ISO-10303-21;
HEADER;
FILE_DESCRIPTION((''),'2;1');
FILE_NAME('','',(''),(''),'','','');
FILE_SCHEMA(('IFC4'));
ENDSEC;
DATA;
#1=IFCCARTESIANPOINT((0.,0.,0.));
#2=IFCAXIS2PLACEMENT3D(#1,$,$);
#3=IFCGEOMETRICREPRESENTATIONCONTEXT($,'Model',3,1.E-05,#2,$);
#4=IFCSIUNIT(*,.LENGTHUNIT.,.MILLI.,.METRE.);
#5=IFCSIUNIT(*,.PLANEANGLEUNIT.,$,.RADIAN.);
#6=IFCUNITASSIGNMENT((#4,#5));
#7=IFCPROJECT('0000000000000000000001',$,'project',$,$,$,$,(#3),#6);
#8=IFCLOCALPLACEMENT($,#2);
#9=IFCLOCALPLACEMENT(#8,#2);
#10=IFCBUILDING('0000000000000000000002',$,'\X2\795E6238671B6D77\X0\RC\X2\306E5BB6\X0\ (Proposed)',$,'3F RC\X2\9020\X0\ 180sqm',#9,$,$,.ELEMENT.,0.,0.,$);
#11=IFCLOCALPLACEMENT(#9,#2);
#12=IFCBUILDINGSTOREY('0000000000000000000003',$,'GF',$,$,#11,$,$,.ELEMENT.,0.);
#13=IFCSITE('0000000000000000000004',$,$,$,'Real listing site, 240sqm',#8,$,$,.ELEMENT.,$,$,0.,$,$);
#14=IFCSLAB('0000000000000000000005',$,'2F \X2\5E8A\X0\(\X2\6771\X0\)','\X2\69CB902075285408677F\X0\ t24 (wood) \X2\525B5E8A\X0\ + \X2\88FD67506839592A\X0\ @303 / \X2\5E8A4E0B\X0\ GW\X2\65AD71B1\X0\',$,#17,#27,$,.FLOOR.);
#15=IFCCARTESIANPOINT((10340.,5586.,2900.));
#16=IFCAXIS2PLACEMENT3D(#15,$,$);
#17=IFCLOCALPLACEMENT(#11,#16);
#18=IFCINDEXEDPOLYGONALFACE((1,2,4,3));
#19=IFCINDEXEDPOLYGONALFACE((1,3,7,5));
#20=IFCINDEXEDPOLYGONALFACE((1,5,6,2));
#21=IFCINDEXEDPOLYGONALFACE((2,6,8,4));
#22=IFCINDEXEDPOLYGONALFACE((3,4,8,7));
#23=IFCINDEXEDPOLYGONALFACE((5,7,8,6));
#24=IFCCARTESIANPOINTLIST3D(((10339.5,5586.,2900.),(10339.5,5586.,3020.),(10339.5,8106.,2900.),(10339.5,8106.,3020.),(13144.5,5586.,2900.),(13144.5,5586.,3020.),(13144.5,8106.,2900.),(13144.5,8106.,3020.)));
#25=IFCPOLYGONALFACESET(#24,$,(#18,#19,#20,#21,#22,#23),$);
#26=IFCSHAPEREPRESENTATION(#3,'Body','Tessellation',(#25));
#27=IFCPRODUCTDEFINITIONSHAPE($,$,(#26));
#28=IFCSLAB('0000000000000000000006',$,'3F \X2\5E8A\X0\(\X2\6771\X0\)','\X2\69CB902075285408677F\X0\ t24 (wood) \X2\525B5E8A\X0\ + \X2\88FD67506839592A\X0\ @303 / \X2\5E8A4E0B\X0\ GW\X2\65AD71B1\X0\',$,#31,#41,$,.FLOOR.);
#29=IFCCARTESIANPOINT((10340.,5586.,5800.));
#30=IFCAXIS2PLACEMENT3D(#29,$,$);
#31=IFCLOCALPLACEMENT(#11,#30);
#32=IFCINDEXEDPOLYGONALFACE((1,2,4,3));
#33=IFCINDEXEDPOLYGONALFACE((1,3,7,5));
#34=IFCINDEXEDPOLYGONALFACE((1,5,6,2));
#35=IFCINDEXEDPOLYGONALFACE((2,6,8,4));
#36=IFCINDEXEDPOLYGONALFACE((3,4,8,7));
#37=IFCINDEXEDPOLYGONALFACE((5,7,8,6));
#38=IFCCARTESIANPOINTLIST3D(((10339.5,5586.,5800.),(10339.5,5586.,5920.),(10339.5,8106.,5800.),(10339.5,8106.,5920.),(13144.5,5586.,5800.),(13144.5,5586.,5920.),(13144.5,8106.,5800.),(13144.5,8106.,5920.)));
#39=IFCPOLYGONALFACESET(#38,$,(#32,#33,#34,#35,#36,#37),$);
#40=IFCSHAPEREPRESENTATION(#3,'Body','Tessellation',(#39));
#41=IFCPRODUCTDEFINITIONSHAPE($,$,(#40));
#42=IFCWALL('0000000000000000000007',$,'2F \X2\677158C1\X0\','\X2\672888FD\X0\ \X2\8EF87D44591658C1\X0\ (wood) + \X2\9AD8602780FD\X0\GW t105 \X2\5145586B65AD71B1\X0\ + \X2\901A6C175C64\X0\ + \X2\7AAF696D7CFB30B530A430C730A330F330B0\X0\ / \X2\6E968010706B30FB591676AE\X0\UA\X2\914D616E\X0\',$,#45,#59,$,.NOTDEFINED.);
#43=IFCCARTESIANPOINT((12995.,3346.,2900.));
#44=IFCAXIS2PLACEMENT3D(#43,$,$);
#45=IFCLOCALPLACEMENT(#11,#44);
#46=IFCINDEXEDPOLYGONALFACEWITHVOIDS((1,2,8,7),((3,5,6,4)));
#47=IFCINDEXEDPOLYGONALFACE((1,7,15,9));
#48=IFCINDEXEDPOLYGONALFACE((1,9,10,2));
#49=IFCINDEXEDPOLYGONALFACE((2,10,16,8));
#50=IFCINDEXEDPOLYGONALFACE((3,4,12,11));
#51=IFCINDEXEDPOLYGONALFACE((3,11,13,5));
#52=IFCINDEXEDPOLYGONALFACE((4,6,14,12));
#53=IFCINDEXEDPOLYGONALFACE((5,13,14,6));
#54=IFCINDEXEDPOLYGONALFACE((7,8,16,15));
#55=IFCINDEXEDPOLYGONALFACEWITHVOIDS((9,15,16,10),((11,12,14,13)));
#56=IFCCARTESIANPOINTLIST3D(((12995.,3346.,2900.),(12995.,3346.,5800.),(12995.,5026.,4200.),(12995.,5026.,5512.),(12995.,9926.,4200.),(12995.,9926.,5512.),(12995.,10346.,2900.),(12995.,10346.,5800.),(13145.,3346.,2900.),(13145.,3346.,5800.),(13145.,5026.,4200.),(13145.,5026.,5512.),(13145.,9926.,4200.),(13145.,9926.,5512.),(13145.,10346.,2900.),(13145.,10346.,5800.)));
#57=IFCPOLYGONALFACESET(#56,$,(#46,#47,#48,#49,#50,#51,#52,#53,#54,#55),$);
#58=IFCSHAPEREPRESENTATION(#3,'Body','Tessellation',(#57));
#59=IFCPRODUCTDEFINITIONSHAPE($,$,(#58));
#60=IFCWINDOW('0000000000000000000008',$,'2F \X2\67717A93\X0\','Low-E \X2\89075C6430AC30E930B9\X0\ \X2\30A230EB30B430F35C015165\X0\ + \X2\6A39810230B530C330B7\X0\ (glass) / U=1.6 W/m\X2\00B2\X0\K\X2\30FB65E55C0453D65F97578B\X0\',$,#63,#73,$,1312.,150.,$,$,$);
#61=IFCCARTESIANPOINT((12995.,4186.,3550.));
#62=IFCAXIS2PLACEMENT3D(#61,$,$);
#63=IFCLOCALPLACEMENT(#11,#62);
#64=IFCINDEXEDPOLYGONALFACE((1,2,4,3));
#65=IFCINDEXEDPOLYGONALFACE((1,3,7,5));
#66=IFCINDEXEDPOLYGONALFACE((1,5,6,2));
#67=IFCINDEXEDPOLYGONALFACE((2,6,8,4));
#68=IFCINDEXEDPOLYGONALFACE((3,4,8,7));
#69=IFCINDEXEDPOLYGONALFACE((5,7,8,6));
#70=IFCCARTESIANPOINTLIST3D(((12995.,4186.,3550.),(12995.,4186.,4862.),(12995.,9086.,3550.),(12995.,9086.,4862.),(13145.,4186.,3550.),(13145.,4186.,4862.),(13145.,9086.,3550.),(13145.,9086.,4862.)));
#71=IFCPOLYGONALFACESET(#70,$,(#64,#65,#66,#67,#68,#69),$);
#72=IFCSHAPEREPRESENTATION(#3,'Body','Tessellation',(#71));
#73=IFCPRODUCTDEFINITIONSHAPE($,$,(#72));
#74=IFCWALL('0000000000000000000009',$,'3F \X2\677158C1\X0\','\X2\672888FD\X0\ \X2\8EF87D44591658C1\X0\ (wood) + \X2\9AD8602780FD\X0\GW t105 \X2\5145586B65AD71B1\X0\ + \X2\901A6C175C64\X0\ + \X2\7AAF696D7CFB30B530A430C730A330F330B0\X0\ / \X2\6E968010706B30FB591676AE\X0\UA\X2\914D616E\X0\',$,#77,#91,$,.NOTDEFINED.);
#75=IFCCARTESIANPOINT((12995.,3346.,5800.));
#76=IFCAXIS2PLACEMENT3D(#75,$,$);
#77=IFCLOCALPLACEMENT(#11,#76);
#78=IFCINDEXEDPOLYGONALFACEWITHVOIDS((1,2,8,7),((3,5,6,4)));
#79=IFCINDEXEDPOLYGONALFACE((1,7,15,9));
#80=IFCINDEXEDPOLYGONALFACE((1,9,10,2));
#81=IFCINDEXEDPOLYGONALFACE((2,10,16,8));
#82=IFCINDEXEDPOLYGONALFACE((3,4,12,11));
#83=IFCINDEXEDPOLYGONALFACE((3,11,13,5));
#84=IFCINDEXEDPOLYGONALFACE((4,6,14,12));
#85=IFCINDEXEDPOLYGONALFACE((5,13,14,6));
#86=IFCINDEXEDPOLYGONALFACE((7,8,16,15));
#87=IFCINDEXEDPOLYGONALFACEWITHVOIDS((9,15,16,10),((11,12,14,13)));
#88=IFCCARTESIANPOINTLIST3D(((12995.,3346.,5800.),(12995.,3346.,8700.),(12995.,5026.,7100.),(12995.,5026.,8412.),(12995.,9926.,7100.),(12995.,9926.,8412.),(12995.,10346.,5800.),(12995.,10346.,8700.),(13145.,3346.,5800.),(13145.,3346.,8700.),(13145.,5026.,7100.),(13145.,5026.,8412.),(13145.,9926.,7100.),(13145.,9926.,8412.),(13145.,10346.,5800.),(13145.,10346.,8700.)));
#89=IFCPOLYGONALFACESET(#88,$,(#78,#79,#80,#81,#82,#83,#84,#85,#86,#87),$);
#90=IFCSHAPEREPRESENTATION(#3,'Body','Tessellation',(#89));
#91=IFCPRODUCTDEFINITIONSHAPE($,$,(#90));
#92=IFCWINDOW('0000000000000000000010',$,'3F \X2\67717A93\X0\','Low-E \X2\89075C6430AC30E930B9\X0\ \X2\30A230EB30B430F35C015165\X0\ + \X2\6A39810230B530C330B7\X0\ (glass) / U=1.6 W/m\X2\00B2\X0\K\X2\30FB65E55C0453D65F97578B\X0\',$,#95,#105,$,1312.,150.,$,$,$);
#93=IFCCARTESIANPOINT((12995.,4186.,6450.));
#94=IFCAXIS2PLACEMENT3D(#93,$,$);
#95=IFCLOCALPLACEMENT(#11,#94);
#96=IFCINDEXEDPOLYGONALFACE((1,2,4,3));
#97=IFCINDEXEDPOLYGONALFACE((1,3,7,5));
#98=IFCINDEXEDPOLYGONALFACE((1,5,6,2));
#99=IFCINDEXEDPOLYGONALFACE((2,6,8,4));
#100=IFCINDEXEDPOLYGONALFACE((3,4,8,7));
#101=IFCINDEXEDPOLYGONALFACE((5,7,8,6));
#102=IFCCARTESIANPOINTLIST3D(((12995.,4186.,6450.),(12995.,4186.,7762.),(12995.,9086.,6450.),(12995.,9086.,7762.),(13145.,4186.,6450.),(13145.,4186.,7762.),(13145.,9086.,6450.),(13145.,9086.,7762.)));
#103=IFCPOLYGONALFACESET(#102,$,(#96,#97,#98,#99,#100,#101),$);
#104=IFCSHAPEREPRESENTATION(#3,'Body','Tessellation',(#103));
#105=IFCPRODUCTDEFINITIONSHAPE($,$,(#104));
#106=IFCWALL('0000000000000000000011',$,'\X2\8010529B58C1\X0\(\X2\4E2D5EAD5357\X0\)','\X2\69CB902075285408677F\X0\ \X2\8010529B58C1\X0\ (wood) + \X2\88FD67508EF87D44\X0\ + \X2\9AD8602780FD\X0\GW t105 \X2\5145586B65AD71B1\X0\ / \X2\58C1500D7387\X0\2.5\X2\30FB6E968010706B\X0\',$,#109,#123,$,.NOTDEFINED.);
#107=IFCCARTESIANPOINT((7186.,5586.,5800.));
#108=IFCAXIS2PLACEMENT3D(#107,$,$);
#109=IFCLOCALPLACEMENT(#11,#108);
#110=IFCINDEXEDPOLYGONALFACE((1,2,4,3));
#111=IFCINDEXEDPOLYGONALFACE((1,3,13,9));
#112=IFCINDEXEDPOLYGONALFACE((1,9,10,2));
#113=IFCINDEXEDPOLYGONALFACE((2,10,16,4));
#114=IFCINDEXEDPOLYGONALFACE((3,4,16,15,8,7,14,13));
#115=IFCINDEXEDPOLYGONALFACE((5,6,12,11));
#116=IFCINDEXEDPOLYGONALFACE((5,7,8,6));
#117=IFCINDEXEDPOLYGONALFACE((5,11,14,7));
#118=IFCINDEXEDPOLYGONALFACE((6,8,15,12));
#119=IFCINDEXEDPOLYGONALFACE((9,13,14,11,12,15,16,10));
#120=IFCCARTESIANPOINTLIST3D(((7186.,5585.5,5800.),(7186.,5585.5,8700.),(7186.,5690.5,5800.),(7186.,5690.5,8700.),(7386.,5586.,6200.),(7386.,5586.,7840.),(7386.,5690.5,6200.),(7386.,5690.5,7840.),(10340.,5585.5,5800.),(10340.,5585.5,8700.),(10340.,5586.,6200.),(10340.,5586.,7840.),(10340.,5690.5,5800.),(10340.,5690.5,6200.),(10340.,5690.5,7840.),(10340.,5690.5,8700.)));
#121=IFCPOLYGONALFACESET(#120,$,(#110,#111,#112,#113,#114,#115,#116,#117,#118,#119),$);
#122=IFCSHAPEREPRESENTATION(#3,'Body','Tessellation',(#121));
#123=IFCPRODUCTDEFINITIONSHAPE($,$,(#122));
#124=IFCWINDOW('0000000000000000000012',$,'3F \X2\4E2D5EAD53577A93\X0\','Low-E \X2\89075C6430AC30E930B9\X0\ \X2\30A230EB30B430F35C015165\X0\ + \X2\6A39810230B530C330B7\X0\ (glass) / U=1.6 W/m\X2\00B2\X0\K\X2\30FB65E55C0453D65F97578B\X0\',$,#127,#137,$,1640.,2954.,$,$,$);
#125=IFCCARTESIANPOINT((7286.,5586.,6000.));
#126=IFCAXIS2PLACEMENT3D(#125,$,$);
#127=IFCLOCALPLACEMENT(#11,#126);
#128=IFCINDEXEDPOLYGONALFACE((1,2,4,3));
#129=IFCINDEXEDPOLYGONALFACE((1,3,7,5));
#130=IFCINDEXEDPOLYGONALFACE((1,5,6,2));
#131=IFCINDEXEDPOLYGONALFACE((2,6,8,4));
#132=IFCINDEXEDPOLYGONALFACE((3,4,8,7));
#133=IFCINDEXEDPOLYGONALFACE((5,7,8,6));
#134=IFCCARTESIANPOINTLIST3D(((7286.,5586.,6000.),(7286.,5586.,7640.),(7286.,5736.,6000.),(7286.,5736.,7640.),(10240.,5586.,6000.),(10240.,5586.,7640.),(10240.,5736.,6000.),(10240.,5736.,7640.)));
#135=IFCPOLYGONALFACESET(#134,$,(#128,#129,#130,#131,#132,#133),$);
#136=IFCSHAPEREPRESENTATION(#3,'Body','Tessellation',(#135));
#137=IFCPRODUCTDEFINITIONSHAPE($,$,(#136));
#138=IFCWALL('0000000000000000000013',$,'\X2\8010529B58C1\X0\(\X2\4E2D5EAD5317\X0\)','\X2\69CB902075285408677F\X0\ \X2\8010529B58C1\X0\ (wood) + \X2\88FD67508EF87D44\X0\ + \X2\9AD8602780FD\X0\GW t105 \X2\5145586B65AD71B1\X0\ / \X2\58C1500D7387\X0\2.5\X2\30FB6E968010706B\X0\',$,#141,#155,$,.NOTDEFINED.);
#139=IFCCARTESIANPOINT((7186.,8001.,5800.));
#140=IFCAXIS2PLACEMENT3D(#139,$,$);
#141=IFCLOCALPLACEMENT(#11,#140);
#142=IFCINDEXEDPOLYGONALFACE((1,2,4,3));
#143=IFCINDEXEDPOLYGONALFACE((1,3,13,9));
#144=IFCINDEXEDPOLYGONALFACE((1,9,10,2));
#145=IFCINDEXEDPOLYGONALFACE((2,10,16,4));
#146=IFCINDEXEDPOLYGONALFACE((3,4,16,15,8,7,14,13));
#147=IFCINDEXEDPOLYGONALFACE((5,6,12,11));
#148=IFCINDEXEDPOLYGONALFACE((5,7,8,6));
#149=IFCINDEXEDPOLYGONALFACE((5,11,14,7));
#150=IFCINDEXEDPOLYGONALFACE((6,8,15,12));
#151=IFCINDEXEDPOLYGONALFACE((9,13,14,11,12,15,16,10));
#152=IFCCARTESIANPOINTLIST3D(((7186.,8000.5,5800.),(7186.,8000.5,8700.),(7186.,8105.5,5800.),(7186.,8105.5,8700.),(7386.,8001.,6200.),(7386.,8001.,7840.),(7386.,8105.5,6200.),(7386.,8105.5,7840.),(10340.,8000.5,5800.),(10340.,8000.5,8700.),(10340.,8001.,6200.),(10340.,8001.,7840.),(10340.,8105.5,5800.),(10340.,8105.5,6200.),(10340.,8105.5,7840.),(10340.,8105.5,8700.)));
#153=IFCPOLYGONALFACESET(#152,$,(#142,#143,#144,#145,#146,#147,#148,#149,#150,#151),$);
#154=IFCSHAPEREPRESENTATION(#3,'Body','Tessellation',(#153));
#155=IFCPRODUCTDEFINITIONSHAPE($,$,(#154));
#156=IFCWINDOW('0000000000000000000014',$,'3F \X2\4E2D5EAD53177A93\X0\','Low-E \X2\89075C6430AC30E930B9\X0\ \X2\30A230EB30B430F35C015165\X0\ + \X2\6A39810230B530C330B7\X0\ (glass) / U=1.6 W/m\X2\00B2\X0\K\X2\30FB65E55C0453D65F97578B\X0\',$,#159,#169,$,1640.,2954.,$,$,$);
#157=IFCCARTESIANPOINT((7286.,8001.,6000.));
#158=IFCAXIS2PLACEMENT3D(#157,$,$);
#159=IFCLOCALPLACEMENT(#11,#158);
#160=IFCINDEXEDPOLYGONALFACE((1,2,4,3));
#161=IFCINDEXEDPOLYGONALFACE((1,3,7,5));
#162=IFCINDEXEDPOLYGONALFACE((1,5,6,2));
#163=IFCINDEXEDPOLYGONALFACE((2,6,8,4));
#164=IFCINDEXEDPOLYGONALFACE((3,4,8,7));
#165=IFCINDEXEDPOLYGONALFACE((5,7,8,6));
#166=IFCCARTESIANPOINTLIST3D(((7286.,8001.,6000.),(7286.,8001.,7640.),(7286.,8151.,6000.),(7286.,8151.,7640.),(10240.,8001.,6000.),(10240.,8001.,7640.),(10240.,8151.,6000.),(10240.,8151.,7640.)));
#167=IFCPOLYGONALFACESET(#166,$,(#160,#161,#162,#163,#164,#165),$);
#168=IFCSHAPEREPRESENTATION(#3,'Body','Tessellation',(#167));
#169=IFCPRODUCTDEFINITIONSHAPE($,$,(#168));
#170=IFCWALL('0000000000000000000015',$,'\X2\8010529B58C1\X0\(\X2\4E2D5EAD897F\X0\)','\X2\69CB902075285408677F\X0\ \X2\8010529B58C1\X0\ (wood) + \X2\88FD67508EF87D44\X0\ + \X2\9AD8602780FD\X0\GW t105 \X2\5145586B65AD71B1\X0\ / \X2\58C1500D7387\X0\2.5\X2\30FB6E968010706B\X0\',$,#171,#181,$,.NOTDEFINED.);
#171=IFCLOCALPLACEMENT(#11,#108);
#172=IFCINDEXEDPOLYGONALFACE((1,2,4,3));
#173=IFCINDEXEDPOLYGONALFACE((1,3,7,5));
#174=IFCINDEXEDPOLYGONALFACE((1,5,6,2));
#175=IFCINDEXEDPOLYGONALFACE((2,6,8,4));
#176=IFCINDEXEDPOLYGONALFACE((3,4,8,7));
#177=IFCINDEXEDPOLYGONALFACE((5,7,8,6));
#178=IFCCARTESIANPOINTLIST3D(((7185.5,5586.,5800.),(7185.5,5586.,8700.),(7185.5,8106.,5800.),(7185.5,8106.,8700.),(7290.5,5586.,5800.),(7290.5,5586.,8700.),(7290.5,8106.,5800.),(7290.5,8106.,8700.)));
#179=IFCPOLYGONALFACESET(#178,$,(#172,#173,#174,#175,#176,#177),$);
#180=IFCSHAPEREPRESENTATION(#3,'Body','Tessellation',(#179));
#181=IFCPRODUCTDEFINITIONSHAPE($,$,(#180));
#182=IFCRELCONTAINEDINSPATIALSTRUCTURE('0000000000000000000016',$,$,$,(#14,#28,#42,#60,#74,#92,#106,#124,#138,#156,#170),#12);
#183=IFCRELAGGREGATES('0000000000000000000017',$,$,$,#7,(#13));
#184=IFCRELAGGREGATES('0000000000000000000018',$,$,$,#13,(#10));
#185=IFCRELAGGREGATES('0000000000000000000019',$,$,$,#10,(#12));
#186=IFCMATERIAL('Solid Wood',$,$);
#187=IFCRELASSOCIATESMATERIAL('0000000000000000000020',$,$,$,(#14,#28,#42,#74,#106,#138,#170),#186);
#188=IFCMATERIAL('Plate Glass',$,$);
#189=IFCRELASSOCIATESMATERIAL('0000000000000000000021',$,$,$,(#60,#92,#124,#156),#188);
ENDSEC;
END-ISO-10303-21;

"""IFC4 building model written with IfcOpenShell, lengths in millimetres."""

from ifc_helpers import new_model, si_unit, frame, frame_2d, origin, place, context, project, spatial, rectangle, extrude, material, element, fill, save


model = new_model("IFC4")

# Units and contexts
model_context = context("Model", 3, precision=1e-05, world=origin())
ifc_project = project(units=[si_unit("LENGTHUNIT", "METRE", prefix="MILLI"), si_unit("PLANEANGLEUNIT", "RADIAN")], contexts=[model_context])

# Site, building, storey
site_placement = place(None, origin())
site = spatial("IfcSite", under=ifc_project, at=site_placement, ObjectType="Real listing site, 240sqm", CompositionType="ELEMENT", RefElevation=0.0)
building_placement = place(site_placement, origin())
building = spatial("IfcBuilding", under=site, at=building_placement, Name="神戸望海RCの家 (Proposed)", ObjectType="3F RC造 180sqm", CompositionType="ELEMENT", ElevationOfRefHeight=0.0, ElevationOfTerrain=0.0)
storey_placement = place(building_placement, origin())
storey = spatial("IfcBuildingStorey", under=building, at=storey_placement, Name="GF", CompositionType="ELEMENT", Elevation=0.0)

# Slabs
ifc_material_1 = material(Name="Solid Wood")
slab_1_placement = place(storey_placement, frame((10340.0, 5586.0, 2900.0)))
element("IfcSlab", 1, at=slab_1_placement, inside=storey, material=ifc_material_1, Name="2F 床(東)", Description="構造用合板 t24 (wood) 剛床 + 製材根太 @303 / 床下 GW断熱", PredefinedType="FLOOR", context=model_context, shape_type="SweptSolid", body=[
    extrude(rectangle(XDim=2805.0, YDim=2520.0, at=frame_2d((1402.0, 1260.0))), frame((10340.0, 5586.0, 2900.0)), (0.0, 0.0, 1.0), 120.0),
])
slab_2_placement = place(storey_placement, frame((10340.0, 5586.0, 5800.0)))
element("IfcSlab", 2, at=slab_2_placement, inside=storey, material=ifc_material_1, Name="3F 床(東)", Description="構造用合板 t24 (wood) 剛床 + 製材根太 @303 / 床下 GW断熱", PredefinedType="FLOOR", context=model_context, shape_type="SweptSolid", body=[
    extrude(rectangle(XDim=2805.0, YDim=2520.0, at=frame_2d((1402.0, 1260.0))), frame((10340.0, 5586.0, 5800.0)), (0.0, 0.0, 1.0), 120.0),
])

# Walls, openings, windows
wall_1_placement = place(storey_placement, frame((12995.0, 3346.0, 2900.0)))
wall_1 = element("IfcWall", 3, at=wall_1_placement, inside=storey, material=ifc_material_1, Name="2F 東壁", Description="木製 軸組外壁 (wood) + 高性能GW t105 充填断熱 + 通気層 + 窯業系サイディング / 準耐火・外皮UA配慮", PredefinedType="NOTDEFINED", context=model_context, shape_type="SweptSolid", body=[
    extrude(rectangle(XDim=150.0, YDim=7000.0, at=frame_2d((75.0, 3500.0))), frame((12995.0, 3346.0, 2900.0)), (0.0, 0.0, 1.0), 2900.0),
])
opening_1_placement = place(storey_placement, frame((12995.0, 4186.0, 3550.0)))
opening_1 = element("IfcOpeningElement", 4, at=opening_1_placement, cuts=wall_1, PredefinedType="NOTDEFINED", context=model_context, shape_type="SweptSolid", body=[
    extrude(rectangle(XDim=150.0, YDim=4900.0, at=frame_2d((75.0, 2450.0))), frame((12995.0, 4186.0, 3550.0)), (0.0, 0.0, 1.0), 1312.0),
])
ifc_material_2 = material(Name="Plate Glass")
window_1_placement = place(storey_placement, frame((12995.0, 4186.0, 3550.0)))
window_1 = element("IfcWindow", 5, at=window_1_placement, inside=storey, material=ifc_material_2, Name="2F 東窓", Description="Low-E 複層ガラス アルゴン封入 + 樹脂サッシ (glass) / U=1.6 W/m²K・日射取得型", OverallHeight=1312.0, OverallWidth=150.0, context=model_context, shape_type="SweptSolid", body=[
    extrude(rectangle(XDim=150.0, YDim=4900.0, at=frame_2d((75.0, 2450.0))), frame((12995.0, 4186.0, 3550.0)), (0.0, 0.0, 1.0), 1312.0),
])
fill(opening_1, window_1)
wall_2_placement = place(storey_placement, frame((12995.0, 3346.0, 5800.0)))
wall_2 = element("IfcWall", 6, at=wall_2_placement, inside=storey, material=ifc_material_1, Name="3F 東壁", Description="木製 軸組外壁 (wood) + 高性能GW t105 充填断熱 + 通気層 + 窯業系サイディング / 準耐火・外皮UA配慮", PredefinedType="NOTDEFINED", context=model_context, shape_type="SweptSolid", body=[
    extrude(rectangle(XDim=150.0, YDim=7000.0, at=frame_2d((75.0, 3500.0))), frame((12995.0, 3346.0, 5800.0)), (0.0, 0.0, 1.0), 2900.0),
])
opening_2_placement = place(storey_placement, frame((12995.0, 4186.0, 6450.0)))
opening_2 = element("IfcOpeningElement", 7, at=opening_2_placement, cuts=wall_2, PredefinedType="NOTDEFINED", context=model_context, shape_type="SweptSolid", body=[
    extrude(rectangle(XDim=150.0, YDim=4900.0, at=frame_2d((75.0, 2450.0))), frame((12995.0, 4186.0, 6450.0)), (0.0, 0.0, 1.0), 1312.0),
])
window_2_placement = place(storey_placement, frame((12995.0, 4186.0, 6450.0)))
window_2 = element("IfcWindow", 8, at=window_2_placement, inside=storey, material=ifc_material_2, Name="3F 東窓", Description="Low-E 複層ガラス アルゴン封入 + 樹脂サッシ (glass) / U=1.6 W/m²K・日射取得型", OverallHeight=1312.0, OverallWidth=150.0, context=model_context, shape_type="SweptSolid", body=[
    extrude(rectangle(XDim=150.0, YDim=4900.0, at=frame_2d((75.0, 2450.0))), frame((12995.0, 4186.0, 6450.0)), (0.0, 0.0, 1.0), 1312.0),
])
fill(opening_2, window_2)
wall_3_placement = place(storey_placement, frame((7186.0, 5586.0, 5800.0)))
wall_3 = element("IfcWall", 9, at=wall_3_placement, inside=storey, material=ifc_material_1, Name="耐力壁(中庭南)", Description="構造用合板 耐力壁 (wood) + 製材軸組 + 高性能GW t105 充填断熱 / 壁倍率2.5・準耐火", PredefinedType="NOTDEFINED", context=model_context, shape_type="SweptSolid", body=[
    extrude(rectangle(XDim=3154.0, YDim=105.0, at=frame_2d((1577.0, 52.0))), frame((7186.0, 5586.0, 5800.0)), (0.0, 0.0, 1.0), 2900.0),
])
opening_3_placement = place(storey_placement, frame((7286.0, 5586.0, 6000.0)))
opening_3 = element("IfcOpeningElement", 10, at=opening_3_placement, cuts=wall_3, PredefinedType="NOTDEFINED", context=model_context, shape_type="SweptSolid", body=[
    extrude(rectangle(XDim=2954.0, YDim=150.0, at=frame_2d((1477.0, 75.0))), frame((7286.0, 5586.0, 6000.0)), (0.0, 0.0, 1.0), 1640.0),
])
window_3_placement = place(storey_placement, frame((7286.0, 5586.0, 6000.0)))
window_3 = element("IfcWindow", 11, at=window_3_placement, inside=storey, material=ifc_material_2, Name="3F 中庭南窓", Description="Low-E 複層ガラス アルゴン封入 + 樹脂サッシ (glass) / U=1.6 W/m²K・日射取得型", OverallHeight=1640.0, OverallWidth=2954.0, context=model_context, shape_type="SweptSolid", body=[
    extrude(rectangle(XDim=2954.0, YDim=150.0, at=frame_2d((1477.0, 75.0))), frame((7286.0, 5586.0, 6000.0)), (0.0, 0.0, 1.0), 1640.0),
])
fill(opening_3, window_3)
wall_4_placement = place(storey_placement, frame((7186.0, 8001.0, 5800.0)))
wall_4 = element("IfcWall", 12, at=wall_4_placement, inside=storey, material=ifc_material_1, Name="耐力壁(中庭北)", Description="構造用合板 耐力壁 (wood) + 製材軸組 + 高性能GW t105 充填断熱 / 壁倍率2.5・準耐火", PredefinedType="NOTDEFINED", context=model_context, shape_type="SweptSolid", body=[
    extrude(rectangle(XDim=3154.0, YDim=105.0, at=frame_2d((1577.0, 52.0))), frame((7186.0, 8001.0, 5800.0)), (0.0, 0.0, 1.0), 2900.0),
])
opening_4_placement = place(storey_placement, frame((7286.0, 8001.0, 6000.0)))
opening_4 = element("IfcOpeningElement", 13, at=opening_4_placement, cuts=wall_4, PredefinedType="NOTDEFINED", context=model_context, shape_type="SweptSolid", body=[
    extrude(rectangle(XDim=2954.0, YDim=150.0, at=frame_2d((1477.0, 75.0))), frame((7286.0, 8001.0, 6000.0)), (0.0, 0.0, 1.0), 1640.0),
])
window_4_placement = place(storey_placement, frame((7286.0, 8001.0, 6000.0)))
window_4 = element("IfcWindow", 14, at=window_4_placement, inside=storey, material=ifc_material_2, Name="3F 中庭北窓", Description="Low-E 複層ガラス アルゴン封入 + 樹脂サッシ (glass) / U=1.6 W/m²K・日射取得型", OverallHeight=1640.0, OverallWidth=2954.0, context=model_context, shape_type="SweptSolid", body=[
    extrude(rectangle(XDim=2954.0, YDim=150.0, at=frame_2d((1477.0, 75.0))), frame((7286.0, 8001.0, 6000.0)), (0.0, 0.0, 1.0), 1640.0),
])
fill(opening_4, window_4)

# Wall
wall_5_placement = place(storey_placement, frame((7186.0, 5586.0, 5800.0)))
element("IfcWall", 15, at=wall_5_placement, inside=storey, material=ifc_material_1, Name="耐力壁(中庭西)", Description="構造用合板 耐力壁 (wood) + 製材軸組 + 高性能GW t105 充填断熱 / 壁倍率2.5・準耐火", PredefinedType="NOTDEFINED", context=model_context, shape_type="SweptSolid", body=[
    extrude(rectangle(XDim=105.0, YDim=2520.0, at=frame_2d((52.0, 1260.0))), frame((7186.0, 5586.0, 5800.0)), (0.0, 0.0, 1.0), 2900.0),
])

save(model, "model.ifc")
